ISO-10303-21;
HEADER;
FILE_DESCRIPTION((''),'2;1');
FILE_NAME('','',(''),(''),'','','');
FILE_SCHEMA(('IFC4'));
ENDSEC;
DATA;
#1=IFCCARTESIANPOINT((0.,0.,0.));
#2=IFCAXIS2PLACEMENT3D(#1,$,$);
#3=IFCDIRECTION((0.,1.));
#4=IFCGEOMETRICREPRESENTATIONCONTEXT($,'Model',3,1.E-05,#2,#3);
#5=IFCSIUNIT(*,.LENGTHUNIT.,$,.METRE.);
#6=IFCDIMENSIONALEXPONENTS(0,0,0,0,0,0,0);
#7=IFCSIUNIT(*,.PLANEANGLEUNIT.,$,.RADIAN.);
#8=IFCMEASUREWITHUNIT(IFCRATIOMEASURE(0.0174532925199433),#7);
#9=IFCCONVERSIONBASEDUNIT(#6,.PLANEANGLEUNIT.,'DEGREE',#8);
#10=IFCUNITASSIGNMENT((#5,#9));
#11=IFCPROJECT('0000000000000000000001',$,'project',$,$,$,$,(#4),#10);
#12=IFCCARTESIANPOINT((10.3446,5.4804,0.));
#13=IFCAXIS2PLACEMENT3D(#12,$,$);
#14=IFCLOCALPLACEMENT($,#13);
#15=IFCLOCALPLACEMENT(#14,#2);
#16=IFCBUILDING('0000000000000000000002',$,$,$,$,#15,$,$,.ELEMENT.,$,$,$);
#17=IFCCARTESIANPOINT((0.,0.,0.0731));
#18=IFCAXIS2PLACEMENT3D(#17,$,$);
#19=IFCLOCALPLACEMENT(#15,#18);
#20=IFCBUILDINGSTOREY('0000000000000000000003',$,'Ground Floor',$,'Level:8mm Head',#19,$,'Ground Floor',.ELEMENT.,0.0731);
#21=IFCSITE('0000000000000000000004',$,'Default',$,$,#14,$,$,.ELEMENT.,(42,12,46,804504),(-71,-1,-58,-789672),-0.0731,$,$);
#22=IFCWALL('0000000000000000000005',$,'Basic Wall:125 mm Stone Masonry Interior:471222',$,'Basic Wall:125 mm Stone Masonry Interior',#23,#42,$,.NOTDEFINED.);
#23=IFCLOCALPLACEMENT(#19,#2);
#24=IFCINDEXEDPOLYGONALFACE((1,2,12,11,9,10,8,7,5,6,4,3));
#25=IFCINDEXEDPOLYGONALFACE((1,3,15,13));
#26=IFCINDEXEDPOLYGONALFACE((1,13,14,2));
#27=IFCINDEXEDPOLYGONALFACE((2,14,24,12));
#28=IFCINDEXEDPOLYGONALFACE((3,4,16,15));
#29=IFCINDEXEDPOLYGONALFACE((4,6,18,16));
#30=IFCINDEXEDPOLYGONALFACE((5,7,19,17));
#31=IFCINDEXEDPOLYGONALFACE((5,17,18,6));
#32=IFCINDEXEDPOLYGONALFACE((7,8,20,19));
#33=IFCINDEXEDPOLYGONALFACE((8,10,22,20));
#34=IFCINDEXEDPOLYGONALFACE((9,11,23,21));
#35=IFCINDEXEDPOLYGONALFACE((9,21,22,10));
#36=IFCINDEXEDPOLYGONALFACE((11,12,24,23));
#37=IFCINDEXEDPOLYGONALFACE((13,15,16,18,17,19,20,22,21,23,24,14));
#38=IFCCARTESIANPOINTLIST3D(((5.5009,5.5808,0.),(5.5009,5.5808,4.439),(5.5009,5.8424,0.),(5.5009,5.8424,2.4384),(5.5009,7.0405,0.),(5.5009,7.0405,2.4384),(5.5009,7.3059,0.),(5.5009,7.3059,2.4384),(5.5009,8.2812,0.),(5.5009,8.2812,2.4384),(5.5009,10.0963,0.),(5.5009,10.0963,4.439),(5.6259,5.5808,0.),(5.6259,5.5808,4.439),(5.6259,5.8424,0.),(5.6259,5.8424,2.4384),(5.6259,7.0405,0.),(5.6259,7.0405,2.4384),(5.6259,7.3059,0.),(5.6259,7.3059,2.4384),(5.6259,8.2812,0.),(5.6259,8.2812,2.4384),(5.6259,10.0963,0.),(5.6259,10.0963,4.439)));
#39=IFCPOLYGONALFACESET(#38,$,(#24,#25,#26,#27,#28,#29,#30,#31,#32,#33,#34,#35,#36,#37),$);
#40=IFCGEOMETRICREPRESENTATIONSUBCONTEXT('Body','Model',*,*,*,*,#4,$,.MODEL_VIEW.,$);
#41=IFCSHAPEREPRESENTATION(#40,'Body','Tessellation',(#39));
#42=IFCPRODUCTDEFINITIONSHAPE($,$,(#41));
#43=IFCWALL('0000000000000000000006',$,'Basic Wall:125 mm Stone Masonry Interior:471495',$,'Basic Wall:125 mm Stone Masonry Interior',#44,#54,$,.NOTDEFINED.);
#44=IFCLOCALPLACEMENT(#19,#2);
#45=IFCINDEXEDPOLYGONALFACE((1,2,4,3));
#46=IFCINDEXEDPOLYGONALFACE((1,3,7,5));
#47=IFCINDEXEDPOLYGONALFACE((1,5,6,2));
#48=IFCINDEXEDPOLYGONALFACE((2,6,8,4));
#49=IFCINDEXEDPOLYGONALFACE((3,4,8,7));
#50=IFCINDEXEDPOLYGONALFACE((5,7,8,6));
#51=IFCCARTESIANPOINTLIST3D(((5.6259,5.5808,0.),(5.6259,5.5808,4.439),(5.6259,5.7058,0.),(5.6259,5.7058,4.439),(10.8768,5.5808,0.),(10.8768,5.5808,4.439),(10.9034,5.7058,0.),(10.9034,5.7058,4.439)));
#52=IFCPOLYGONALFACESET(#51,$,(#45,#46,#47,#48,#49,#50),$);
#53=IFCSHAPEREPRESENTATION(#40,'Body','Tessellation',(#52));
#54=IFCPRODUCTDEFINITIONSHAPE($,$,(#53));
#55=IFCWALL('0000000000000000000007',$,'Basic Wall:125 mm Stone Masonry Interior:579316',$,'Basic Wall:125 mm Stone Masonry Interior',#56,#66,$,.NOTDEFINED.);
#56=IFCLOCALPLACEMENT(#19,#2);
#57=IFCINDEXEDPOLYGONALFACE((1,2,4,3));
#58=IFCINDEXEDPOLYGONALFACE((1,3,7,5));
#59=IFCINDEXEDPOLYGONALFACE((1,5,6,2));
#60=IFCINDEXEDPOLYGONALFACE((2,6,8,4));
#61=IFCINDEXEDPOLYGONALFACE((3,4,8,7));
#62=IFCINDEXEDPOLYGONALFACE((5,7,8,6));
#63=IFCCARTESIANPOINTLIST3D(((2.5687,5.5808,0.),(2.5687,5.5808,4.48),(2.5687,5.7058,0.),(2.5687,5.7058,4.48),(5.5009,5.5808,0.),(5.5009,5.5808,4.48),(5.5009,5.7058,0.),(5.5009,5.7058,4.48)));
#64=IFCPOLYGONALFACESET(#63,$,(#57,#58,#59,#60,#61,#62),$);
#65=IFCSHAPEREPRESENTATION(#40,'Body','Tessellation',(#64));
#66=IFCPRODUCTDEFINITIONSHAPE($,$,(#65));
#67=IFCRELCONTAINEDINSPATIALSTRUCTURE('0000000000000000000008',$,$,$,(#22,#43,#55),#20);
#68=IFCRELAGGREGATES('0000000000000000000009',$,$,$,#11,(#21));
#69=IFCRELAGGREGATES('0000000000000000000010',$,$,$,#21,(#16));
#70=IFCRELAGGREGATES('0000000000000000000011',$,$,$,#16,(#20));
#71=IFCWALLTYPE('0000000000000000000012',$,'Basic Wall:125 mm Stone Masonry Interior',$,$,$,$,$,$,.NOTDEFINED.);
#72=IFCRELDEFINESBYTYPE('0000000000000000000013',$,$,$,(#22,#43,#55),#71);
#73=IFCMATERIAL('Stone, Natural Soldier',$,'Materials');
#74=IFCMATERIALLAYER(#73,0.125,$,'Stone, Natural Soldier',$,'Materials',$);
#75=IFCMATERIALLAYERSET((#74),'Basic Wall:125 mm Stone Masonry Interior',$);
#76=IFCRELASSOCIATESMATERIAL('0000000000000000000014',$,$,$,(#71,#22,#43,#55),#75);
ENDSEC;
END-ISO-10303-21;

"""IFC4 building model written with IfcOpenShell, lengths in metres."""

from ifc_helpers import new_model, entity, si_unit, converted_unit, direction, frame, frame_2d, origin, origin_2d_with_axis, place, context, subcontext, project, spatial, polyline, rectangle, outline, extrude, clip, bounded_halfspace, material, layer, layer_set, layer_usage, type_object, element, save


model = new_model("IFC4")

# Units and contexts
model_context = context("Model", 3, precision=1e-05, world=origin(), true_north=direction((0.0, 1.0)))
body_context = subcontext(model_context, "Body", "Model", "MODEL_VIEW")
ifc_project = project(units=[si_unit("LENGTHUNIT", "METRE"), converted_unit("PLANEANGLEUNIT", "DEGREE", entity("IfcRatioMeasure", 0.0174532925199433), si_unit("PLANEANGLEUNIT", "RADIAN"), dimensions=[0, 0, 0, 0, 0, 0, 0])], contexts=[model_context])

# Site, building, storey
site_placement = place(None, frame((10.3446, 5.4804, 0.0)))
site = spatial("IfcSite", under=ifc_project, at=site_placement, Name="Default", CompositionType="ELEMENT", RefLatitude=(42, 12, 46, 804504), RefLongitude=(-71, -1, -58, -789672), RefElevation=-0.0731)
building_placement = place(site_placement, origin())
building = spatial("IfcBuilding", under=site, at=building_placement, CompositionType="ELEMENT")
storey_placement = place(building_placement, frame((0.0, 0.0, 0.0731)))
storey = spatial("IfcBuildingStorey", under=building, at=storey_placement, Name="Ground Floor", ObjectType="Level:8mm Head", LongName="Ground Floor", CompositionType="ELEMENT", Elevation=0.0731)

# Shared definitions
ifc_material_1 = material(Name="Stone, Natural Soldier", Category="Materials")

# Wall, openings
ifc_layer_1 = layer(ifc_material_1, 0.125, Name="Stone, Natural Soldier", Category="Materials")
ifc_layer_set_1 = layer_set([ifc_layer_1], Name="Basic Wall:125 mm Stone Masonry Interior")
ifc_layer_usage_1 = layer_usage(ifc_layer_set_1, "AXIS2", "NEGATIVE", 0.0625)
wall_type_1 = type_object("IfcWallType", Name="Basic Wall:125 mm Stone Masonry Interior", PredefinedType="NOTDEFINED", material=ifc_layer_set_1)
wall_1_placement = place(storey_placement, frame((5.5634, 10.0963, 0.0), z_axis=(0.0, 0.0, 1.0), x_axis=(0.0, -1.0, 0.0)))
wall_1 = element("IfcWall", 1, at=wall_1_placement, inside=storey, type_object=wall_type_1, material=ifc_layer_usage_1, Name="Basic Wall:125 mm Stone Masonry Interior:471222", ObjectType="Basic Wall:125 mm Stone Masonry Interior", PredefinedType="NOTDEFINED", context=body_context, shape_type="Clipping", body=[
    clip(extrude(rectangle(XDim=4.5155, YDim=0.125, at=frame_2d((2.2578, 0.0), x_axis=(-1.0, 0.0))), origin(), (0.0, 0.0, 1.0), 4.439), bounded_halfspace(frame((0.0, -0.0625, 4.439), z_axis=(0.0, 0.0, -1.0), x_axis=(0.978148, -0.207912, 0.0)), True, frame((0.0, -0.0625, 4.439)), polyline([(0.0, 0.0), (4.5155, 0.0), (4.5155, 0.125), (4.3905, 0.125), (0.0, 0.125), (0.0, 0.0)]))),
])
opening_1_placement = place(wall_1_placement, frame((2.7904, -0.0625, 0.0)))
element("IfcOpeningElement", 2, at=opening_1_placement, cuts=wall_1, ObjectType="Opening", PredefinedType="OPENING", context=body_context, shape_type="SweptSolid", body=[
    extrude(rectangle(XDim=2.4384, YDim=0.9754, at=origin_2d_with_axis()), frame((-0.4877, 0.0, 1.2192), z_axis=(0.0, 1.0, 0.0), x_axis=(0.0, 0.0, -1.0)), (0.0, 0.0, 1.0), 0.125),
])
opening_2_placement = place(wall_1_placement, frame((4.2539, -0.0625, 0.0)))
element("IfcOpeningElement", 3, at=opening_2_placement, cuts=wall_1, ObjectType="Opening", PredefinedType="OPENING", context=body_context, shape_type="SweptSolid", body=[
    extrude(rectangle(XDim=2.4384, YDim=1.1981, at=origin_2d_with_axis()), frame((-0.599, 0.0, 1.2192), z_axis=(0.0, 1.0, 0.0), x_axis=(0.0, 0.0, -1.0)), (0.0, 0.0, 1.0), 0.125),
])

# Walls
ifc_layer_usage_2 = layer_usage(ifc_layer_set_1, "AXIS2", "NEGATIVE", 0.0625)
wall_2_placement = place(storey_placement, frame((5.6259, 5.6433, 0.0)))
element("IfcWall", 4, at=wall_2_placement, inside=storey, type_object=wall_type_1, material=ifc_layer_usage_2, Name="Basic Wall:125 mm Stone Masonry Interior:471495", ObjectType="Basic Wall:125 mm Stone Masonry Interior", PredefinedType="NOTDEFINED", context=body_context, shape_type="Clipping", body=[
    clip(extrude(outline(polyline([(5.2509, -0.0625), (5.2775, 0.0625), (0.0, 0.0625), (0.0, -0.0625), (5.2509, -0.0625)])), origin(), (0.0, 0.0, 1.0), 4.439), bounded_halfspace(frame((0.0, -0.0625, 4.439), z_axis=(0.0, 0.0, -1.0), x_axis=(-0.207912, -0.978148, 0.0)), True, frame((0.0, -0.0625, 4.439)), polyline([(0.0, 0.0), (5.2509, 0.0), (5.2775, 0.125), (0.0, 0.125), (0.0, 0.0)]))),
])
ifc_layer_usage_3 = layer_usage(ifc_layer_set_1, "AXIS2", "NEGATIVE", 0.0625)
wall_3_placement = place(storey_placement, frame((5.5009, 5.6433, 0.0), z_axis=(0.0, 0.0, 1.0), x_axis=(-1.0, 0.0, 0.0)))
element("IfcWall", 5, at=wall_3_placement, inside=storey, type_object=wall_type_1, material=ifc_layer_usage_3, Name="Basic Wall:125 mm Stone Masonry Interior:579316", ObjectType="Basic Wall:125 mm Stone Masonry Interior", PredefinedType="NOTDEFINED", context=body_context, shape_type="SweptSolid", body=[
    extrude(rectangle(XDim=2.9322, YDim=0.125, at=frame_2d((1.4661, 0.0), x_axis=(-1.0, 0.0))), origin(), (0.0, 0.0, 1.0), 4.48),
])

save(model, "model.ifc")
